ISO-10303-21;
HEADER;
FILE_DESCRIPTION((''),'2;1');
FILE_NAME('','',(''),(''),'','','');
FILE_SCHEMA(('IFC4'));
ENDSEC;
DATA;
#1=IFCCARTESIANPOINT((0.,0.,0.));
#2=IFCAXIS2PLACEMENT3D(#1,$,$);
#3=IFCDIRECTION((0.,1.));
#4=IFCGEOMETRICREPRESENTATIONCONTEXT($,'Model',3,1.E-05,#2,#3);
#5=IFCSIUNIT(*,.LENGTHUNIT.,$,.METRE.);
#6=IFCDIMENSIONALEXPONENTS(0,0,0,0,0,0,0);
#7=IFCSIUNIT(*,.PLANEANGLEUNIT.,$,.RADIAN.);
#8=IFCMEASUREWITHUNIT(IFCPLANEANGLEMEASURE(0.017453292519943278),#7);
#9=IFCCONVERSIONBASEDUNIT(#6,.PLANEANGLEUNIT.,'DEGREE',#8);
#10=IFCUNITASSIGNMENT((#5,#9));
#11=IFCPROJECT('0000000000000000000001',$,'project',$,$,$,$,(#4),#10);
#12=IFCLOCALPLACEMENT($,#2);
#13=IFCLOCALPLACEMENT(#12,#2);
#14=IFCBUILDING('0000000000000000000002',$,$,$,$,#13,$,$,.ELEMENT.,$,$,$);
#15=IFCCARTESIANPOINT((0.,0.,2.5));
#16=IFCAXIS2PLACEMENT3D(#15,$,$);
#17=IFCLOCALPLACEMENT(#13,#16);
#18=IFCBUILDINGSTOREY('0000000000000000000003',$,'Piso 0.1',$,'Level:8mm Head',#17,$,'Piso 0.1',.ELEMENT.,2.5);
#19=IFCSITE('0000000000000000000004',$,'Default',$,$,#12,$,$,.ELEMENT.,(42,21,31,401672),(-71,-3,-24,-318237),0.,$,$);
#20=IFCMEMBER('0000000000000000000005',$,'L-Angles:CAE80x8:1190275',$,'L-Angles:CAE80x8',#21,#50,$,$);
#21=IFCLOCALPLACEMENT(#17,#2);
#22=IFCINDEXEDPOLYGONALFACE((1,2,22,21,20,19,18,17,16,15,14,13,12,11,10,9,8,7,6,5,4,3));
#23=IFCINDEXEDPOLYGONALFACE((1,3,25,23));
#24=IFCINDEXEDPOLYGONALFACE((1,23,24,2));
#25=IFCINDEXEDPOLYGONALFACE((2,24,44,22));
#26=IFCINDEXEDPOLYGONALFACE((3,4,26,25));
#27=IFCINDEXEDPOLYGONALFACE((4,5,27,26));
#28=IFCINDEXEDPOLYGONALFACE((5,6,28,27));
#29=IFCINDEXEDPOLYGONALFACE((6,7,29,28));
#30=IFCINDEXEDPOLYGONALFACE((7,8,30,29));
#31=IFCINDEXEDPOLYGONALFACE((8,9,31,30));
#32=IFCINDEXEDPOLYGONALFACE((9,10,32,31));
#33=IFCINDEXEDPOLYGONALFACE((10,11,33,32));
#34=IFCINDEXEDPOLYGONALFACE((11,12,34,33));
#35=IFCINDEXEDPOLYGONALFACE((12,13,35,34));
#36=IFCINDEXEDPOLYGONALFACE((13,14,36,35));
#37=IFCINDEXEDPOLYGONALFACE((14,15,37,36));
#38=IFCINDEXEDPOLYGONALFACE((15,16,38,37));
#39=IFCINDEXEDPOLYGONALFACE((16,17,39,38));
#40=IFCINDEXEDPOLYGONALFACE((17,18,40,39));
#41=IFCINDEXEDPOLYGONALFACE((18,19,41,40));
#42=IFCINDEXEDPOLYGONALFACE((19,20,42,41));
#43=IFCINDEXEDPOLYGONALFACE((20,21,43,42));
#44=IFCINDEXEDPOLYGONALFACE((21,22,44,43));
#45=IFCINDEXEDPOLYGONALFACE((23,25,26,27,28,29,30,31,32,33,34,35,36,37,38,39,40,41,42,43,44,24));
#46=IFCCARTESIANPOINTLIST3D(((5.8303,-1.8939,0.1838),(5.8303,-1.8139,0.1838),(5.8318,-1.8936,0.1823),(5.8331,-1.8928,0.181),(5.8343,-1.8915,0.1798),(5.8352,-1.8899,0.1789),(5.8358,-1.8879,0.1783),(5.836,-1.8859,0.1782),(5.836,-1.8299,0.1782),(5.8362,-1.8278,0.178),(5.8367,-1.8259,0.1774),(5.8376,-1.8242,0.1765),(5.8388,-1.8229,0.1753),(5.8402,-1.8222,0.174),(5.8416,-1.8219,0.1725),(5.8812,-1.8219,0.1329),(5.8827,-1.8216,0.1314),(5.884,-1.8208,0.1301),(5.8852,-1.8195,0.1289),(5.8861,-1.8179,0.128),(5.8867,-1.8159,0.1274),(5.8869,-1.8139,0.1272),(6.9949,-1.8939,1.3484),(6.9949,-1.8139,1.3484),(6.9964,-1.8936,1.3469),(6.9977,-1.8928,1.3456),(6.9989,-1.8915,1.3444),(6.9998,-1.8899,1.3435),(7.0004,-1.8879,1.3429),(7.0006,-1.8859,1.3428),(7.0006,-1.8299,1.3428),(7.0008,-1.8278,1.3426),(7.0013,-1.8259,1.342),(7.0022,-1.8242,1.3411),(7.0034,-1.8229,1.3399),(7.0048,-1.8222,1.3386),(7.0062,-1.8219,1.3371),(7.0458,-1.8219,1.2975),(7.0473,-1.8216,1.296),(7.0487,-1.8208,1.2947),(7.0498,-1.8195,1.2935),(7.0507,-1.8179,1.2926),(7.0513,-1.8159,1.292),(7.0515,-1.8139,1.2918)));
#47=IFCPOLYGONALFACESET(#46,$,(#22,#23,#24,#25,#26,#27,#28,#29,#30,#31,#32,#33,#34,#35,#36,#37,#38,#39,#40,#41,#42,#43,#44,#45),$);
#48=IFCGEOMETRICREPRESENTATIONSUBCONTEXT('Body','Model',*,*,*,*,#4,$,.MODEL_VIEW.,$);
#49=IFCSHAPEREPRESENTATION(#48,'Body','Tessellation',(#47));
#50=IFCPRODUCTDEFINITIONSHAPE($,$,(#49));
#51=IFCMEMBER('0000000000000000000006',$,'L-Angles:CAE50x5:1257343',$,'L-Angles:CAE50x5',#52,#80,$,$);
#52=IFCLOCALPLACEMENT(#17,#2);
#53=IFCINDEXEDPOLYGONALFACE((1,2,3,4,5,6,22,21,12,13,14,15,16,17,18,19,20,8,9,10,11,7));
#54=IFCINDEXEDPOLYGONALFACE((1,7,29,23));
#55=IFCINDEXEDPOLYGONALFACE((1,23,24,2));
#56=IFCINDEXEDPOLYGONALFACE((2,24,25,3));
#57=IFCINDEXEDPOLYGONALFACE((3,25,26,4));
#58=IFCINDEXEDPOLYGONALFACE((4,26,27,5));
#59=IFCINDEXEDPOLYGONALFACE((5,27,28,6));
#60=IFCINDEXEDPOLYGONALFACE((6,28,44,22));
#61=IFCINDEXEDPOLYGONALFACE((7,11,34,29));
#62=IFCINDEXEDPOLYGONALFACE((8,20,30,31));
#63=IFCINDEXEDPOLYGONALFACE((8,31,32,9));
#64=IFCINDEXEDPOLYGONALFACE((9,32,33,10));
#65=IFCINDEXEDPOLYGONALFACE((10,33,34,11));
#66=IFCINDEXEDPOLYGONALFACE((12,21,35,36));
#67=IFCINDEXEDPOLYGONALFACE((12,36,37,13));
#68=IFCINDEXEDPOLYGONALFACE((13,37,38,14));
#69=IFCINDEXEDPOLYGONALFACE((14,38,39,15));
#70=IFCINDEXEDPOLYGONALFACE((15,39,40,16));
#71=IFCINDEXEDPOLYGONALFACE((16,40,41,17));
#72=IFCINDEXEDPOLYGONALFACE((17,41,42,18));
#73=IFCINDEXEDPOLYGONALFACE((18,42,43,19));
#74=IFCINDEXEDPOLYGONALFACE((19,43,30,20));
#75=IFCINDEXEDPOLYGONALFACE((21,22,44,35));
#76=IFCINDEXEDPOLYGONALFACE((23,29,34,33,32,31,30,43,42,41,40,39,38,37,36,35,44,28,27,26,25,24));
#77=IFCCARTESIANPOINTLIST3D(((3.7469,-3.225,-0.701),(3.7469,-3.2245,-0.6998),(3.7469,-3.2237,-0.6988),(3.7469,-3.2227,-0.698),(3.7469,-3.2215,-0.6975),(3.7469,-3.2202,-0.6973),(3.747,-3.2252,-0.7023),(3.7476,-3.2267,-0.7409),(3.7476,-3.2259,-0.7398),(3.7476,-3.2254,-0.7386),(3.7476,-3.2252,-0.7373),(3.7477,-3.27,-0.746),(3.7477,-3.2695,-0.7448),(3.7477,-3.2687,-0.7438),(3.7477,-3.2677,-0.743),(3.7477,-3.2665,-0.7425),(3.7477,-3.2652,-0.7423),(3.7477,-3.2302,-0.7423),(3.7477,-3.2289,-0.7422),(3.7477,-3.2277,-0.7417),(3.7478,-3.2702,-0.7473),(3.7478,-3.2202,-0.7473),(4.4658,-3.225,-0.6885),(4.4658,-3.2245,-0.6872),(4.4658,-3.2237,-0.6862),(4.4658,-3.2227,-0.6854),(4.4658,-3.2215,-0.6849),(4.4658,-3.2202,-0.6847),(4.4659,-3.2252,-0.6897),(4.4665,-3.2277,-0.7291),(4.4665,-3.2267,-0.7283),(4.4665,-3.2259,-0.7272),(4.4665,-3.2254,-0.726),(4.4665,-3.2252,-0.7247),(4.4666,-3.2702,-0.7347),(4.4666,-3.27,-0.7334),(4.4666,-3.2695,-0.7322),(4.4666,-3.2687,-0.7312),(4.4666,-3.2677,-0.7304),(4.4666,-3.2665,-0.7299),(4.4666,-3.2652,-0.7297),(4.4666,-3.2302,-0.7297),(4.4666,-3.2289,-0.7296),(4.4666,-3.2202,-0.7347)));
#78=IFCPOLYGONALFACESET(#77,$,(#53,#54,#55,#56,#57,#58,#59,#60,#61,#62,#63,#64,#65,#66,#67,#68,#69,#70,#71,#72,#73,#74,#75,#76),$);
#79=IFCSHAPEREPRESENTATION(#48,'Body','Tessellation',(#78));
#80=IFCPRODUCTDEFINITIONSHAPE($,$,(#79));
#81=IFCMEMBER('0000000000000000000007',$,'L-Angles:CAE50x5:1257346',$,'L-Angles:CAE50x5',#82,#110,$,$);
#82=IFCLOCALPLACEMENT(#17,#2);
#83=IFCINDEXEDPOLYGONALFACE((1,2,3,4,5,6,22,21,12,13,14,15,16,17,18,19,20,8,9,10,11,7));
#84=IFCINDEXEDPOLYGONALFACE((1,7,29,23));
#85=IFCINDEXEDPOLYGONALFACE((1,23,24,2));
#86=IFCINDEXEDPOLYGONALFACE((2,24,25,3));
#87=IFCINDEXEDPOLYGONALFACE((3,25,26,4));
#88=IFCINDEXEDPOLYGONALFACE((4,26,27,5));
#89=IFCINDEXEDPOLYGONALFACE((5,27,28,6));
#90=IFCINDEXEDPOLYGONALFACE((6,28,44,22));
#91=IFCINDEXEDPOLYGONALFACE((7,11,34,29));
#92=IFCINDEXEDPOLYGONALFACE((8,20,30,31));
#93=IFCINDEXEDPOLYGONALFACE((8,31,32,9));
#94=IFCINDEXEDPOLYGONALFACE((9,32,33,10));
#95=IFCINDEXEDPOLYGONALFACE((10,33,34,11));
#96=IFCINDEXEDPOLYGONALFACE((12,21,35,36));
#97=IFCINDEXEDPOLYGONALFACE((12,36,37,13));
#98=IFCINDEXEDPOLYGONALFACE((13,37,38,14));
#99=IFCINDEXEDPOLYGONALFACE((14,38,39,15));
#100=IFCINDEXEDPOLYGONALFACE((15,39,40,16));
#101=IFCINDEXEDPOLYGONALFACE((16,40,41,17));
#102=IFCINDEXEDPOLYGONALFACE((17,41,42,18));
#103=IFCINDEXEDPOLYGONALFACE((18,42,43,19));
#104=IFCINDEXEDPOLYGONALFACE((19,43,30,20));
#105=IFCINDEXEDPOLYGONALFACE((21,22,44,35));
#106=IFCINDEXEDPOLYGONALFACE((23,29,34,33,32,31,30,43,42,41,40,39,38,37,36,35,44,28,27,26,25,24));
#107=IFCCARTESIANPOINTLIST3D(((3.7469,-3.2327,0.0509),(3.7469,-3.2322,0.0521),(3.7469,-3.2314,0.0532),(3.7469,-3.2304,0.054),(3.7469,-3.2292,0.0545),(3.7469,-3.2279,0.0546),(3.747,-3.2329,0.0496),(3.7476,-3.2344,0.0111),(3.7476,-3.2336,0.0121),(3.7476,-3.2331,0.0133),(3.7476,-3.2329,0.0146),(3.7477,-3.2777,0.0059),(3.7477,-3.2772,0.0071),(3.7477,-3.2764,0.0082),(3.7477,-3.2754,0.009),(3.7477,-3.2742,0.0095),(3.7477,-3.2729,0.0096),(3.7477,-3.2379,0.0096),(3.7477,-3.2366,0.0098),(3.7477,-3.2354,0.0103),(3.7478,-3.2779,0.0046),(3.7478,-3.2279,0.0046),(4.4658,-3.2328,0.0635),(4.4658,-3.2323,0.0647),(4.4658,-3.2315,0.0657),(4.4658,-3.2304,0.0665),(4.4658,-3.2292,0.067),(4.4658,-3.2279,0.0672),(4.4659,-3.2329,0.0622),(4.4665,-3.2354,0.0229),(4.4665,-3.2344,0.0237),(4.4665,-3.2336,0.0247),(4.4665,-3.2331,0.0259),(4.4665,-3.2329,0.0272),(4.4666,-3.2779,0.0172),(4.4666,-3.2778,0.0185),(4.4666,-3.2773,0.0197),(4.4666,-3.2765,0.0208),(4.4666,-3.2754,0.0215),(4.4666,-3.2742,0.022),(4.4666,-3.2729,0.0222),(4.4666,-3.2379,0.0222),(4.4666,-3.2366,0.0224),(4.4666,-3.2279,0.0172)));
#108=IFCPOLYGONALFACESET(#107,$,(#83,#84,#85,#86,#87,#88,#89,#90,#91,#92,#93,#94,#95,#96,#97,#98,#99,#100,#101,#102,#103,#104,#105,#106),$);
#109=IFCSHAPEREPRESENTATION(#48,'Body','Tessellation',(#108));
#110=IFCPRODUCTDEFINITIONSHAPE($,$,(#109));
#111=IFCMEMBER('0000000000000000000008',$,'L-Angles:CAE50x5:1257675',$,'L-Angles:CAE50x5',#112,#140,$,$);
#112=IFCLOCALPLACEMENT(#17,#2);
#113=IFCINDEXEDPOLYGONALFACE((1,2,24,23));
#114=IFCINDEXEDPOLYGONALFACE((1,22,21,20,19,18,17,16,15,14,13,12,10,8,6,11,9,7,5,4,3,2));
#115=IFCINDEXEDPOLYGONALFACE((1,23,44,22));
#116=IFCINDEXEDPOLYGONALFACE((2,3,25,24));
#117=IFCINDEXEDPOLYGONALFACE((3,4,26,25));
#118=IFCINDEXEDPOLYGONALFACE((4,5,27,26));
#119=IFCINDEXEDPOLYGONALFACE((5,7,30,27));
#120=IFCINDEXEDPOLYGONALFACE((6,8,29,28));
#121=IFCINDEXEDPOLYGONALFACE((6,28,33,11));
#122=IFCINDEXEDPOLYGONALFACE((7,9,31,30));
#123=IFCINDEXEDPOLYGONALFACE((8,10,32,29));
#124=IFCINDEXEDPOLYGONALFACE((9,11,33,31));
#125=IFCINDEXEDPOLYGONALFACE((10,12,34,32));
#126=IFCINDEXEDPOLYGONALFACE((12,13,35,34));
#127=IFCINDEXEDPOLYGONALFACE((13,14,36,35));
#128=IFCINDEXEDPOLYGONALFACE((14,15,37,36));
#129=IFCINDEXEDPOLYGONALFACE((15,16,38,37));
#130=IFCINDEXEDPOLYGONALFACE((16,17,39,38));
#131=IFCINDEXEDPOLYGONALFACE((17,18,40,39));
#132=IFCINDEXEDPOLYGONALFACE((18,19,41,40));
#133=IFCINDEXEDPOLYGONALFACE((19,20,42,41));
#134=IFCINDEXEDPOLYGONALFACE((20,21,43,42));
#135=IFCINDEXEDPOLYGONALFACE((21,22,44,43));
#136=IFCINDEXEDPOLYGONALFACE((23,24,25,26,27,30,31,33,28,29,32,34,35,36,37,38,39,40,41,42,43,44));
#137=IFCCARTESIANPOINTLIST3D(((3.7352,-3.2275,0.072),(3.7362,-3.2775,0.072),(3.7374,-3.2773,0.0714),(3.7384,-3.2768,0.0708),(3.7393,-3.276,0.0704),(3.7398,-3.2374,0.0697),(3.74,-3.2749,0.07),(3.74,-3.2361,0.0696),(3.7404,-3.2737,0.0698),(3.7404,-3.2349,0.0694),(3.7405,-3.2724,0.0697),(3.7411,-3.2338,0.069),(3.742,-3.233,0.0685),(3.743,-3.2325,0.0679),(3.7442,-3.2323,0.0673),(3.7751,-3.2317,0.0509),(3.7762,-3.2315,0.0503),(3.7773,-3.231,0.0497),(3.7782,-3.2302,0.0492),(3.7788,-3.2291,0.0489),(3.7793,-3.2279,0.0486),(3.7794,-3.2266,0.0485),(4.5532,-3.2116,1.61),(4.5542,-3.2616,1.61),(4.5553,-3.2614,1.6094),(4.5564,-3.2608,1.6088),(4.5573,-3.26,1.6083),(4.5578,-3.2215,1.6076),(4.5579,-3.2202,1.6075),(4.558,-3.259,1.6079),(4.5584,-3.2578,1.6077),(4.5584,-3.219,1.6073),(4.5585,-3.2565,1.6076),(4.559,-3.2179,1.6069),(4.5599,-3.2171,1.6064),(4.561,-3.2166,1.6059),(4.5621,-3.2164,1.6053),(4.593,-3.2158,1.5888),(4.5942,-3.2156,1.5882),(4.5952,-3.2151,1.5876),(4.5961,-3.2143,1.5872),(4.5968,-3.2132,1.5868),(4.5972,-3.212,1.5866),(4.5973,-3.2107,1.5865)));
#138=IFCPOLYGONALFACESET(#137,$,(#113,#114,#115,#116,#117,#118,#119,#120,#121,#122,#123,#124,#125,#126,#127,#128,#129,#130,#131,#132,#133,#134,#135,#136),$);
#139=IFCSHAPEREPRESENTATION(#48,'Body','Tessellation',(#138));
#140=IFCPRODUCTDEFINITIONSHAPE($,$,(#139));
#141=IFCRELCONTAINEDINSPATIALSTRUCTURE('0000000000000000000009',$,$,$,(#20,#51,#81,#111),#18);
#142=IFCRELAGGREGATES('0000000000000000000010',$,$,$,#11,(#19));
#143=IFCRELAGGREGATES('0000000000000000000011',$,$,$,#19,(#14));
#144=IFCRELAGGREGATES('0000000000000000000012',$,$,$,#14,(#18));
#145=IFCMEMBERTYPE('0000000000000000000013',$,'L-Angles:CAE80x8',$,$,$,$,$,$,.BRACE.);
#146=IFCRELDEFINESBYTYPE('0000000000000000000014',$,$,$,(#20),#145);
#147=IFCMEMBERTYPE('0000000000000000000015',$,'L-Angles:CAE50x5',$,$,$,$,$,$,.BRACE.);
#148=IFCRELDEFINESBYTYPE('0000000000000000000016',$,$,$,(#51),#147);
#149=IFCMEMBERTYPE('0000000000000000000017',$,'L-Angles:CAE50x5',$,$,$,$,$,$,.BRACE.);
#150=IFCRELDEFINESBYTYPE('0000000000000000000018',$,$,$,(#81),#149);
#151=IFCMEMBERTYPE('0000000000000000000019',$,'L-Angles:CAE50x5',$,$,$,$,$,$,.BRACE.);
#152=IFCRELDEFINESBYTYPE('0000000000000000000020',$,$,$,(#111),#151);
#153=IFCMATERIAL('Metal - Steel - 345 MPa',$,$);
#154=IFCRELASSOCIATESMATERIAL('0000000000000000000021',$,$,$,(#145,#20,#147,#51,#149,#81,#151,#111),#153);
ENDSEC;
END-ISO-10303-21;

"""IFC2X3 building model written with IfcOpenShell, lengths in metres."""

from ifc_helpers import new_model, entity, si_unit, converted_unit, direction, frame, frame_2d, origin, place, context, subcontext, project, spatial, polyline, circle_curve, parameter, trimmed, segment, composite_curve, outline, extrude, source, transform, mapped, material, type_object, type_shapes, element, save


model = new_model("IFC2X3")

# Units and contexts
model_context = context("Model", 3, precision=1e-05, world=origin(), true_north=direction((0.0, 1.0)))
body_context = subcontext(model_context, "Body", "Model", "MODEL_VIEW")
ifc_project = project(units=[si_unit("LENGTHUNIT", "METRE"), converted_unit("PLANEANGLEUNIT", "DEGREE", entity("IfcPlaneAngleMeasure", 0.017453292519943278), si_unit("PLANEANGLEUNIT", "RADIAN"), dimensions=[0, 0, 0, 0, 0, 0, 0])], contexts=[model_context])

# Site, building, storey
site_placement = place(None, origin())
site = spatial("IfcSite", under=ifc_project, at=site_placement, Name="Default", CompositionType="ELEMENT", RefLatitude=(42, 21, 31, 401672), RefLongitude=(-71, -3, -24, -318237), RefElevation=0.0)
building_placement = place(site_placement, origin())
building = spatial("IfcBuilding", under=site, at=building_placement, CompositionType="ELEMENT")
storey_placement = place(building_placement, frame((0.0, 0.0, 2.5)))
storey = spatial("IfcBuildingStorey", under=building, at=storey_placement, Name="Piso 0.1", ObjectType="Level:8mm Head", LongName="Piso 0.1", CompositionType="ELEMENT", Elevation=2.5)

# Members
ifc_material = material(Name="Metal - Steel - 345 MPa")
member_type_1 = type_object("IfcMemberType", Name="L-Angles:CAE80x8", PredefinedType="BRACE", material=ifc_material)
shared_shape_1 = source(origin(), body_context, "Body", "SweptSolid", [
    extrude(outline(composite_curve([segment(polyline([(-0.0263, -0.0263), (0.0537, -0.0263)]), True, "CONTINUOUS"), segment(trimmed(circle_curve(frame_2d((0.0457, -0.0263), x_axis=(1.0, 0.0)), 0.008), [parameter(0.0)], [parameter(90.0)], True, "PARAMETER"), True, "CONTINUOUS"), segment(polyline([(0.0457, -0.0183), (-0.0103, -0.0183)]), True, "CONTINUOUS"), segment(trimmed(circle_curve(frame_2d((-0.0103, -0.0103), x_axis=(1.0, 0.0)), 0.008), [parameter(180.0)], [parameter(270.0)], True, "PARAMETER"), False, "CONTINUOUS"), segment(polyline([(-0.0183, -0.0103), (-0.0183, 0.0457)]), True, "CONTINUOUS"), segment(trimmed(circle_curve(frame_2d((-0.0263, 0.0457), x_axis=(1.0, 0.0)), 0.008), [parameter(0.0)], [parameter(90.0)], True, "PARAMETER"), True, "CONTINUOUS"), segment(polyline([(-0.0263, 0.0537), (-0.0263, -0.0263)]), True, "CONTINUOUS")], self_intersect=False)), frame((-0.829, -0.0037, -0.0037), z_axis=(1.0, 0.0, 0.0), x_axis=(0.0, -1.0, 0.0)), (0.0, 0.0, 1.0), 1.647),
])
type_shapes(member_type_1, [shared_shape_1])
member_1_placement = place(storey_placement, frame((6.4325, -1.8365, 0.754), z_axis=(-0.707107, 0.0, 0.707107), x_axis=(0.707107, 0.0, 0.707107)))
element("IfcMember", 1, at=member_1_placement, inside=storey, type_object=member_type_1, material=ifc_material, Name="L-Angles:CAE80x8:1190275", ObjectType="L-Angles:CAE80x8", context=body_context, shape_type="MappedRepresentation", body=[
    mapped(shared_shape_1, transform((0.0, 0.0, 0.0), scale=1.0)),
])
member_type_2 = type_object("IfcMemberType", Name="L-Angles:CAE50x5", PredefinedType="BRACE", material=ifc_material)
shared_shape_2 = source(origin(), body_context, "Body", "SweptSolid", [
    extrude(outline(composite_curve([segment(polyline([(-0.0164, -0.0164), (0.0336, -0.0164)]), True, "CONTINUOUS"), segment(trimmed(circle_curve(frame_2d((0.0286, -0.0164), x_axis=(1.0, 0.0)), 0.005), [parameter(0.0)], [parameter(90.0)], True, "PARAMETER"), True, "CONTINUOUS"), segment(polyline([(0.0286, -0.0114), (-0.0064, -0.0114)]), True, "CONTINUOUS"), segment(trimmed(circle_curve(frame_2d((-0.0064, -0.0064), x_axis=(1.0, 0.0)), 0.005), [parameter(180.0)], [parameter(270.0)], True, "PARAMETER"), False, "CONTINUOUS"), segment(polyline([(-0.0114, -0.0064), (-0.0114, 0.0286)]), True, "CONTINUOUS"), segment(trimmed(circle_curve(frame_2d((-0.0164, 0.0286), x_axis=(1.0, 0.0)), 0.005), [parameter(0.0)], [parameter(90.0)], True, "PARAMETER"), True, "CONTINUOUS"), segment(polyline([(-0.0164, 0.0336), (-0.0164, -0.0164)]), True, "CONTINUOUS")], self_intersect=False)), frame((-0.359, -0.0024, -0.0024), z_axis=(1.0, 0.0, 0.0), x_axis=(0.0, -1.0, 0.0)), (0.0, 0.0, 1.0), 0.719),
])
type_shapes(member_type_2, [shared_shape_2])
member_2_placement = place(storey_placement, frame((4.1065, -3.2342, -0.727), z_axis=(0.000017, 1.0, 0.0), x_axis=(0.999847, -0.000017, 0.017497)))
element("IfcMember", 2, at=member_2_placement, inside=storey, type_object=member_type_2, material=ifc_material, Name="L-Angles:CAE50x5:1257343", ObjectType="L-Angles:CAE50x5", context=body_context, shape_type="MappedRepresentation", body=[
    mapped(shared_shape_2, transform((0.0, 0.0, 0.0), scale=1.0)),
])
member_type_3 = type_object("IfcMemberType", Name="L-Angles:CAE50x5", PredefinedType="BRACE", material=ifc_material)
shared_shape_3 = source(origin(), body_context, "Body", "SweptSolid", [
    extrude(outline(composite_curve([segment(polyline([(-0.0164, -0.0164), (0.0336, -0.0164)]), True, "CONTINUOUS"), segment(trimmed(circle_curve(frame_2d((0.0286, -0.0164), x_axis=(1.0, 0.0)), 0.005), [parameter(0.0)], [parameter(90.0)], True, "PARAMETER"), True, "CONTINUOUS"), segment(polyline([(0.0286, -0.0114), (-0.0064, -0.0114)]), True, "CONTINUOUS"), segment(trimmed(circle_curve(frame_2d((-0.0064, -0.0064), x_axis=(1.0, 0.0)), 0.005), [parameter(180.0)], [parameter(270.0)], True, "PARAMETER"), False, "CONTINUOUS"), segment(polyline([(-0.0114, -0.0064), (-0.0114, 0.0286)]), True, "CONTINUOUS"), segment(trimmed(circle_curve(frame_2d((-0.0164, 0.0286), x_axis=(1.0, 0.0)), 0.005), [parameter(0.0)], [parameter(90.0)], True, "PARAMETER"), True, "CONTINUOUS"), segment(polyline([(-0.0164, 0.0336), (-0.0164, -0.0164)]), True, "CONTINUOUS")], self_intersect=False)), frame((-0.359, -0.0024, -0.0024), z_axis=(1.0, 0.0, 0.0), x_axis=(0.0, -1.0, 0.0)), (0.0, 0.0, 1.0), 0.719),
])
type_shapes(member_type_3, [shared_shape_3])
member_3_placement = place(storey_placement, frame((4.1065, -3.2419, 0.0249), z_axis=(0.000035, 1.0, 0.0), x_axis=(0.999847, -0.000035, 0.017497)))
element("IfcMember", 3, at=member_3_placement, inside=storey, type_object=member_type_3, material=ifc_material, Name="L-Angles:CAE50x5:1257346", ObjectType="L-Angles:CAE50x5", context=body_context, shape_type="MappedRepresentation", body=[
    mapped(shared_shape_3, transform((0.0, 0.0, 0.0), scale=1.0)),
])
member_type_4 = type_object("IfcMemberType", Name="L-Angles:CAE50x5", PredefinedType="BRACE", material=ifc_material)
shared_shape_4 = source(origin(), body_context, "Body", "SweptSolid", [
    extrude(outline(composite_curve([segment(polyline([(-0.0164, -0.0164), (0.0336, -0.0164)]), True, "CONTINUOUS"), segment(trimmed(circle_curve(frame_2d((0.0286, -0.0164), x_axis=(1.0, 0.0)), 0.005), [parameter(0.0)], [parameter(90.0)], True, "PARAMETER"), True, "CONTINUOUS"), segment(polyline([(0.0286, -0.0114), (-0.0064, -0.0114)]), True, "CONTINUOUS"), segment(trimmed(circle_curve(frame_2d((-0.0064, -0.0064), x_axis=(1.0, 0.0)), 0.005), [parameter(180.0)], [parameter(270.0)], True, "PARAMETER"), False, "CONTINUOUS"), segment(polyline([(-0.0114, -0.0064), (-0.0114, 0.0286)]), True, "CONTINUOUS"), segment(trimmed(circle_curve(frame_2d((-0.0164, 0.0286), x_axis=(1.0, 0.0)), 0.005), [parameter(0.0)], [parameter(90.0)], True, "PARAMETER"), True, "CONTINUOUS"), segment(polyline([(-0.0164, 0.0336), (-0.0164, -0.0164)]), True, "CONTINUOUS")], self_intersect=False)), frame((-0.7905, -0.0024, -0.0024), z_axis=(1.0, 0.0, 0.0), x_axis=(0.0, -1.0, 0.0)), (0.0, 0.0, 1.0), 1.742),
])
type_shapes(member_type_4, [shared_shape_4])
member_4_placement = place(storey_placement, frame((4.1191, -3.234, 0.7633), z_axis=(-0.882689, -0.017177, 0.469643), x_axis=(0.469555, 0.009137, 0.882856)))
element("IfcMember", 4, at=member_4_placement, inside=storey, type_object=member_type_4, material=ifc_material, Name="L-Angles:CAE50x5:1257675", ObjectType="L-Angles:CAE50x5", context=body_context, shape_type="MappedRepresentation", body=[
    mapped(shared_shape_4, transform((0.0, 0.0, 0.0), scale=1.0)),
])

save(model, "model.ifc")
